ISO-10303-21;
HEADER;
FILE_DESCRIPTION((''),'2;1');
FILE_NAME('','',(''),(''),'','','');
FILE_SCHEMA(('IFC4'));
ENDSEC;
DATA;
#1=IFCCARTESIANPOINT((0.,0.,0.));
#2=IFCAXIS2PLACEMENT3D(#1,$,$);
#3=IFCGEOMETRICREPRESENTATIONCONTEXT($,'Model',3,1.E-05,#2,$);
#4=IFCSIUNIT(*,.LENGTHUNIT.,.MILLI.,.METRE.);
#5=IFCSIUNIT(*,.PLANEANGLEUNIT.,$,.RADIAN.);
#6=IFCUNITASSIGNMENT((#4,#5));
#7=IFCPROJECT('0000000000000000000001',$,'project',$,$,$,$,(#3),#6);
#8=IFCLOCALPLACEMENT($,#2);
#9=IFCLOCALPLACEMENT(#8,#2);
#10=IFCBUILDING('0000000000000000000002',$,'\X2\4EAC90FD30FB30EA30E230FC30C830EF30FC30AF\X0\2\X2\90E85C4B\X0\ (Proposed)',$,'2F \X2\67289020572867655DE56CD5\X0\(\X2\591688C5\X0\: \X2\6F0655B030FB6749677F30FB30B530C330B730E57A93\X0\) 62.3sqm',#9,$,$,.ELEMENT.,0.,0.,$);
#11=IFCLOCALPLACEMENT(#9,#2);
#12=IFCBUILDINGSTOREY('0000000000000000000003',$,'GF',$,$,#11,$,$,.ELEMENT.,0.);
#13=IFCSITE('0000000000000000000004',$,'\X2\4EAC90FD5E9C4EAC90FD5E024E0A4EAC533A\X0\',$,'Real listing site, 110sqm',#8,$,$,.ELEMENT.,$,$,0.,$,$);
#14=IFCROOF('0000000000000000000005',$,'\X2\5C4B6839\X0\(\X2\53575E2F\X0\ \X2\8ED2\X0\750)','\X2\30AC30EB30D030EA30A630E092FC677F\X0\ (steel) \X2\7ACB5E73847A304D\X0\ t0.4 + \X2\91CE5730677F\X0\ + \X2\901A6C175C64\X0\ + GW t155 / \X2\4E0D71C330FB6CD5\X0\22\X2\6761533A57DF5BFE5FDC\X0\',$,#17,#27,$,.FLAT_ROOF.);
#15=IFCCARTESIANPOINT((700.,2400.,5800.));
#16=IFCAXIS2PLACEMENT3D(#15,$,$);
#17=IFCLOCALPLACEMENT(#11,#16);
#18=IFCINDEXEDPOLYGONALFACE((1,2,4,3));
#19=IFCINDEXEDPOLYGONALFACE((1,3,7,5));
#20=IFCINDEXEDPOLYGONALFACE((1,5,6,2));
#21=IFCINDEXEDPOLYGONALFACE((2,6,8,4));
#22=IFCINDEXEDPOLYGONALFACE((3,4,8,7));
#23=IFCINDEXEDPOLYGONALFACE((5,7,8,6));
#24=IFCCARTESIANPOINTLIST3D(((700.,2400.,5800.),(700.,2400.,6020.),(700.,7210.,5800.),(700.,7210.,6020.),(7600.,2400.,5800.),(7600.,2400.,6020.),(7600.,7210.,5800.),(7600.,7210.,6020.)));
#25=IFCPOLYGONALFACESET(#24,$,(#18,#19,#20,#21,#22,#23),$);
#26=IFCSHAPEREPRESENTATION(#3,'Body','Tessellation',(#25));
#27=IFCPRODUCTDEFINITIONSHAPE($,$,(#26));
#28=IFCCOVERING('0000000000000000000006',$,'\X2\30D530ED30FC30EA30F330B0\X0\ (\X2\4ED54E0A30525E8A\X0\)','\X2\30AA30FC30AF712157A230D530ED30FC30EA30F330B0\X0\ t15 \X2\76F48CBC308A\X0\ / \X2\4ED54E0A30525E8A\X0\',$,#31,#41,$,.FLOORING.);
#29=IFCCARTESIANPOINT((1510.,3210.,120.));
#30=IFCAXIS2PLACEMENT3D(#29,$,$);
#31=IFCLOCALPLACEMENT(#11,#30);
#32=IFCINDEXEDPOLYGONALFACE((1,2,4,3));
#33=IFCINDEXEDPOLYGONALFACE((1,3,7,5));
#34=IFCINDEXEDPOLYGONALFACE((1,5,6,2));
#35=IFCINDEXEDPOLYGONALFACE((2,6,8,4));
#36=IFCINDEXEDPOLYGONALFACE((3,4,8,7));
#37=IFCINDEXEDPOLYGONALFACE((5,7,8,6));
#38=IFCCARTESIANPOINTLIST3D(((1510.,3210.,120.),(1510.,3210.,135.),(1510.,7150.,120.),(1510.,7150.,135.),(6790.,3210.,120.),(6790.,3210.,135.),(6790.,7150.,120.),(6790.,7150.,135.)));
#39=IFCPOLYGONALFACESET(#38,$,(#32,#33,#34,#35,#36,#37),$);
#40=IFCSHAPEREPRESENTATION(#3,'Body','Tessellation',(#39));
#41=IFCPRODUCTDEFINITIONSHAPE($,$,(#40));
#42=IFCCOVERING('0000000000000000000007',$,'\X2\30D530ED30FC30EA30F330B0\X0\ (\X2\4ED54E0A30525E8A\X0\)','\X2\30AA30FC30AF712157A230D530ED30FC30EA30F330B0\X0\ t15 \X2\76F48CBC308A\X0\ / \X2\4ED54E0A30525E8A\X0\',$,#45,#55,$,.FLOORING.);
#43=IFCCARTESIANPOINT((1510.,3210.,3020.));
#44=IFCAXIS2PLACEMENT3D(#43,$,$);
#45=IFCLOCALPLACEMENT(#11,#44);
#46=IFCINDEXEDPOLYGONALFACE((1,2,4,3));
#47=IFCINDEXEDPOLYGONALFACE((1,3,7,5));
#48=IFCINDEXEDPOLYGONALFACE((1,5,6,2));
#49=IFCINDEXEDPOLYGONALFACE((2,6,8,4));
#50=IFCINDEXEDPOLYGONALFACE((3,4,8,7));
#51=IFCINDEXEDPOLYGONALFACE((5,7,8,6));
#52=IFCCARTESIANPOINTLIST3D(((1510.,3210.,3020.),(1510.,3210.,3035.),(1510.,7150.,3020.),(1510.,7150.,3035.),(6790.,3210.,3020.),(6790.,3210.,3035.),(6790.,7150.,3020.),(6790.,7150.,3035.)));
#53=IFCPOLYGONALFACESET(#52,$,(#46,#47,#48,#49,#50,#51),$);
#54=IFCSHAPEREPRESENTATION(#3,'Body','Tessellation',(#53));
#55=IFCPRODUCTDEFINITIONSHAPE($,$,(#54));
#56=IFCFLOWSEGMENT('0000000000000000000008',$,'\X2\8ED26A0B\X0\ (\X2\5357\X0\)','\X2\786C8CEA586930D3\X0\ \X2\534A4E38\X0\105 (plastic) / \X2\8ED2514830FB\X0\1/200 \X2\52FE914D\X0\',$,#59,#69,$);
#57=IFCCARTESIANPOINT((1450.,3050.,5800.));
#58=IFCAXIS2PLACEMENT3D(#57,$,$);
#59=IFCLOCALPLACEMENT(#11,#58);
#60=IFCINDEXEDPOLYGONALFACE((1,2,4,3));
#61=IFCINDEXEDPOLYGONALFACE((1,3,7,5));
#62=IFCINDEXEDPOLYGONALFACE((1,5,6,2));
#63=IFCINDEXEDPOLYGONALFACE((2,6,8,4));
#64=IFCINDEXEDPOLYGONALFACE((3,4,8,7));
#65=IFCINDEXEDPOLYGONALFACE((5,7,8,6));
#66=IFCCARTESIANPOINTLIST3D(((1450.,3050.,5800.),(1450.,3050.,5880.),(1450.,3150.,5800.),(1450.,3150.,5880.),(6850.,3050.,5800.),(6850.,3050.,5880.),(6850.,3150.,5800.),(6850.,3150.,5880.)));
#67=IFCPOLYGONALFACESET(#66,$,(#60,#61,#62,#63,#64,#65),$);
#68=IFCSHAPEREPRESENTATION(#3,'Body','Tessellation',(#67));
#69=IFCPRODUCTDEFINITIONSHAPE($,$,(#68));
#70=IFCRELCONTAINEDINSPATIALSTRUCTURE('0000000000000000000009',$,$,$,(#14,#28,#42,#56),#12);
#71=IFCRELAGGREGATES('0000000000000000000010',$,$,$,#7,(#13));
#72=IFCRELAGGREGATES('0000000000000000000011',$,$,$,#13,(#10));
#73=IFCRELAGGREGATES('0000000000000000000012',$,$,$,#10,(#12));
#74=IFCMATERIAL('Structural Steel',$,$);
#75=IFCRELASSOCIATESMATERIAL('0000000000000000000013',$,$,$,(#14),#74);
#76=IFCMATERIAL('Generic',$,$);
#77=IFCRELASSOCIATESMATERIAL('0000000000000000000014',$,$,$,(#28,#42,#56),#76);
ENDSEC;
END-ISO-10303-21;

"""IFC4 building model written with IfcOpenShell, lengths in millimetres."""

from ifc_helpers import new_model, si_unit, frame, frame_2d, origin, place, context, project, spatial, rectangle, extrude, material, element, save


model = new_model("IFC4")

# Units and contexts
model_context = context("Model", 3, precision=1e-05, world=origin())
ifc_project = project(units=[si_unit("LENGTHUNIT", "METRE", prefix="MILLI"), si_unit("PLANEANGLEUNIT", "RADIAN")], contexts=[model_context])

# Site, building, storey
site_placement = place(None, origin())
site = spatial("IfcSite", under=ifc_project, at=site_placement, Name="京都府京都市上京区", ObjectType="Real listing site, 110sqm", CompositionType="ELEMENT", RefElevation=0.0)
building_placement = place(site_placement, origin())
building = spatial("IfcBuilding", under=site, at=building_placement, Name="京都・リモートワーク2部屋 (Proposed)", ObjectType="2F 木造在来工法(外装: 漆喰・杉板・サッシュ窓) 62.3sqm", CompositionType="ELEMENT", ElevationOfRefHeight=0.0, ElevationOfTerrain=0.0)
storey_placement = place(building_placement, origin())
storey = spatial("IfcBuildingStorey", under=building, at=storey_placement, Name="GF", CompositionType="ELEMENT", Elevation=0.0)

# Roof
ifc_material_1 = material(Name="Structural Steel")
for number, where, name in (
    (1, (700.0, 2400.0, 5800.0), "屋根(南帯 軒750)"),
):
    element("IfcRoof", number, at=place(storey_placement, frame(where)), inside=storey, material=ifc_material_1, Name=name, Description="ガルバリウム鋼板 (steel) 立平葺き t0.4 + 野地板 + 通気層 + GW t155 / 不燃・法22条区域対応", PredefinedType="FLAT_ROOF", context=model_context, shape_type="SweptSolid", body=[
        extrude(rectangle(XDim=6900.0, YDim=4810.0, at=frame_2d((3450.0, 2405.0))), frame((700.0, 2400.0, 5800.0)), (0.0, 0.0, 1.0), 220.0),
    ])

# Coverings
ifc_material_2 = material(Name="Generic")
covering_1_placement = place(storey_placement, frame((1510.0, 3210.0, 120.0)))
element("IfcCovering", 2, at=covering_1_placement, inside=storey, material=ifc_material_2, Name="フローリング (仕上げ床)", Description="オーク無垢フローリング t15 直貼り / 仕上げ床", PredefinedType="FLOORING", context=model_context, shape_type="SweptSolid", body=[
    extrude(rectangle(XDim=5280.0, YDim=3940.0, at=frame_2d((2640.0, 1970.0))), frame((1510.0, 3210.0, 120.0)), (0.0, 0.0, 1.0), 15.0),
])
covering_2_placement = place(storey_placement, frame((1510.0, 3210.0, 3020.0)))
element("IfcCovering", 3, at=covering_2_placement, inside=storey, material=ifc_material_2, Name="フローリング (仕上げ床)", Description="オーク無垢フローリング t15 直貼り / 仕上げ床", PredefinedType="FLOORING", context=model_context, shape_type="SweptSolid", body=[
    extrude(rectangle(XDim=5280.0, YDim=3940.0, at=frame_2d((2640.0, 1970.0))), frame((1510.0, 3210.0, 3020.0)), (0.0, 0.0, 1.0), 15.0),
])

# Flow segment
flow_segment_placement = place(storey_placement, frame((1450.0, 3050.0, 5800.0)))
element("IfcFlowSegment", 4, at=flow_segment_placement, inside=storey, material=ifc_material_2, Name="軒樋 (南)", Description="硬質塩ビ 半丸105 (plastic) / 軒先・1/200 勾配", context=model_context, shape_type="SweptSolid", body=[
    extrude(rectangle(XDim=5400.0, YDim=100.0, at=frame_2d((2700.0, 50.0))), frame((1450.0, 3050.0, 5800.0)), (0.0, 0.0, 1.0), 80.0),
])

save(model, "model.ifc")
